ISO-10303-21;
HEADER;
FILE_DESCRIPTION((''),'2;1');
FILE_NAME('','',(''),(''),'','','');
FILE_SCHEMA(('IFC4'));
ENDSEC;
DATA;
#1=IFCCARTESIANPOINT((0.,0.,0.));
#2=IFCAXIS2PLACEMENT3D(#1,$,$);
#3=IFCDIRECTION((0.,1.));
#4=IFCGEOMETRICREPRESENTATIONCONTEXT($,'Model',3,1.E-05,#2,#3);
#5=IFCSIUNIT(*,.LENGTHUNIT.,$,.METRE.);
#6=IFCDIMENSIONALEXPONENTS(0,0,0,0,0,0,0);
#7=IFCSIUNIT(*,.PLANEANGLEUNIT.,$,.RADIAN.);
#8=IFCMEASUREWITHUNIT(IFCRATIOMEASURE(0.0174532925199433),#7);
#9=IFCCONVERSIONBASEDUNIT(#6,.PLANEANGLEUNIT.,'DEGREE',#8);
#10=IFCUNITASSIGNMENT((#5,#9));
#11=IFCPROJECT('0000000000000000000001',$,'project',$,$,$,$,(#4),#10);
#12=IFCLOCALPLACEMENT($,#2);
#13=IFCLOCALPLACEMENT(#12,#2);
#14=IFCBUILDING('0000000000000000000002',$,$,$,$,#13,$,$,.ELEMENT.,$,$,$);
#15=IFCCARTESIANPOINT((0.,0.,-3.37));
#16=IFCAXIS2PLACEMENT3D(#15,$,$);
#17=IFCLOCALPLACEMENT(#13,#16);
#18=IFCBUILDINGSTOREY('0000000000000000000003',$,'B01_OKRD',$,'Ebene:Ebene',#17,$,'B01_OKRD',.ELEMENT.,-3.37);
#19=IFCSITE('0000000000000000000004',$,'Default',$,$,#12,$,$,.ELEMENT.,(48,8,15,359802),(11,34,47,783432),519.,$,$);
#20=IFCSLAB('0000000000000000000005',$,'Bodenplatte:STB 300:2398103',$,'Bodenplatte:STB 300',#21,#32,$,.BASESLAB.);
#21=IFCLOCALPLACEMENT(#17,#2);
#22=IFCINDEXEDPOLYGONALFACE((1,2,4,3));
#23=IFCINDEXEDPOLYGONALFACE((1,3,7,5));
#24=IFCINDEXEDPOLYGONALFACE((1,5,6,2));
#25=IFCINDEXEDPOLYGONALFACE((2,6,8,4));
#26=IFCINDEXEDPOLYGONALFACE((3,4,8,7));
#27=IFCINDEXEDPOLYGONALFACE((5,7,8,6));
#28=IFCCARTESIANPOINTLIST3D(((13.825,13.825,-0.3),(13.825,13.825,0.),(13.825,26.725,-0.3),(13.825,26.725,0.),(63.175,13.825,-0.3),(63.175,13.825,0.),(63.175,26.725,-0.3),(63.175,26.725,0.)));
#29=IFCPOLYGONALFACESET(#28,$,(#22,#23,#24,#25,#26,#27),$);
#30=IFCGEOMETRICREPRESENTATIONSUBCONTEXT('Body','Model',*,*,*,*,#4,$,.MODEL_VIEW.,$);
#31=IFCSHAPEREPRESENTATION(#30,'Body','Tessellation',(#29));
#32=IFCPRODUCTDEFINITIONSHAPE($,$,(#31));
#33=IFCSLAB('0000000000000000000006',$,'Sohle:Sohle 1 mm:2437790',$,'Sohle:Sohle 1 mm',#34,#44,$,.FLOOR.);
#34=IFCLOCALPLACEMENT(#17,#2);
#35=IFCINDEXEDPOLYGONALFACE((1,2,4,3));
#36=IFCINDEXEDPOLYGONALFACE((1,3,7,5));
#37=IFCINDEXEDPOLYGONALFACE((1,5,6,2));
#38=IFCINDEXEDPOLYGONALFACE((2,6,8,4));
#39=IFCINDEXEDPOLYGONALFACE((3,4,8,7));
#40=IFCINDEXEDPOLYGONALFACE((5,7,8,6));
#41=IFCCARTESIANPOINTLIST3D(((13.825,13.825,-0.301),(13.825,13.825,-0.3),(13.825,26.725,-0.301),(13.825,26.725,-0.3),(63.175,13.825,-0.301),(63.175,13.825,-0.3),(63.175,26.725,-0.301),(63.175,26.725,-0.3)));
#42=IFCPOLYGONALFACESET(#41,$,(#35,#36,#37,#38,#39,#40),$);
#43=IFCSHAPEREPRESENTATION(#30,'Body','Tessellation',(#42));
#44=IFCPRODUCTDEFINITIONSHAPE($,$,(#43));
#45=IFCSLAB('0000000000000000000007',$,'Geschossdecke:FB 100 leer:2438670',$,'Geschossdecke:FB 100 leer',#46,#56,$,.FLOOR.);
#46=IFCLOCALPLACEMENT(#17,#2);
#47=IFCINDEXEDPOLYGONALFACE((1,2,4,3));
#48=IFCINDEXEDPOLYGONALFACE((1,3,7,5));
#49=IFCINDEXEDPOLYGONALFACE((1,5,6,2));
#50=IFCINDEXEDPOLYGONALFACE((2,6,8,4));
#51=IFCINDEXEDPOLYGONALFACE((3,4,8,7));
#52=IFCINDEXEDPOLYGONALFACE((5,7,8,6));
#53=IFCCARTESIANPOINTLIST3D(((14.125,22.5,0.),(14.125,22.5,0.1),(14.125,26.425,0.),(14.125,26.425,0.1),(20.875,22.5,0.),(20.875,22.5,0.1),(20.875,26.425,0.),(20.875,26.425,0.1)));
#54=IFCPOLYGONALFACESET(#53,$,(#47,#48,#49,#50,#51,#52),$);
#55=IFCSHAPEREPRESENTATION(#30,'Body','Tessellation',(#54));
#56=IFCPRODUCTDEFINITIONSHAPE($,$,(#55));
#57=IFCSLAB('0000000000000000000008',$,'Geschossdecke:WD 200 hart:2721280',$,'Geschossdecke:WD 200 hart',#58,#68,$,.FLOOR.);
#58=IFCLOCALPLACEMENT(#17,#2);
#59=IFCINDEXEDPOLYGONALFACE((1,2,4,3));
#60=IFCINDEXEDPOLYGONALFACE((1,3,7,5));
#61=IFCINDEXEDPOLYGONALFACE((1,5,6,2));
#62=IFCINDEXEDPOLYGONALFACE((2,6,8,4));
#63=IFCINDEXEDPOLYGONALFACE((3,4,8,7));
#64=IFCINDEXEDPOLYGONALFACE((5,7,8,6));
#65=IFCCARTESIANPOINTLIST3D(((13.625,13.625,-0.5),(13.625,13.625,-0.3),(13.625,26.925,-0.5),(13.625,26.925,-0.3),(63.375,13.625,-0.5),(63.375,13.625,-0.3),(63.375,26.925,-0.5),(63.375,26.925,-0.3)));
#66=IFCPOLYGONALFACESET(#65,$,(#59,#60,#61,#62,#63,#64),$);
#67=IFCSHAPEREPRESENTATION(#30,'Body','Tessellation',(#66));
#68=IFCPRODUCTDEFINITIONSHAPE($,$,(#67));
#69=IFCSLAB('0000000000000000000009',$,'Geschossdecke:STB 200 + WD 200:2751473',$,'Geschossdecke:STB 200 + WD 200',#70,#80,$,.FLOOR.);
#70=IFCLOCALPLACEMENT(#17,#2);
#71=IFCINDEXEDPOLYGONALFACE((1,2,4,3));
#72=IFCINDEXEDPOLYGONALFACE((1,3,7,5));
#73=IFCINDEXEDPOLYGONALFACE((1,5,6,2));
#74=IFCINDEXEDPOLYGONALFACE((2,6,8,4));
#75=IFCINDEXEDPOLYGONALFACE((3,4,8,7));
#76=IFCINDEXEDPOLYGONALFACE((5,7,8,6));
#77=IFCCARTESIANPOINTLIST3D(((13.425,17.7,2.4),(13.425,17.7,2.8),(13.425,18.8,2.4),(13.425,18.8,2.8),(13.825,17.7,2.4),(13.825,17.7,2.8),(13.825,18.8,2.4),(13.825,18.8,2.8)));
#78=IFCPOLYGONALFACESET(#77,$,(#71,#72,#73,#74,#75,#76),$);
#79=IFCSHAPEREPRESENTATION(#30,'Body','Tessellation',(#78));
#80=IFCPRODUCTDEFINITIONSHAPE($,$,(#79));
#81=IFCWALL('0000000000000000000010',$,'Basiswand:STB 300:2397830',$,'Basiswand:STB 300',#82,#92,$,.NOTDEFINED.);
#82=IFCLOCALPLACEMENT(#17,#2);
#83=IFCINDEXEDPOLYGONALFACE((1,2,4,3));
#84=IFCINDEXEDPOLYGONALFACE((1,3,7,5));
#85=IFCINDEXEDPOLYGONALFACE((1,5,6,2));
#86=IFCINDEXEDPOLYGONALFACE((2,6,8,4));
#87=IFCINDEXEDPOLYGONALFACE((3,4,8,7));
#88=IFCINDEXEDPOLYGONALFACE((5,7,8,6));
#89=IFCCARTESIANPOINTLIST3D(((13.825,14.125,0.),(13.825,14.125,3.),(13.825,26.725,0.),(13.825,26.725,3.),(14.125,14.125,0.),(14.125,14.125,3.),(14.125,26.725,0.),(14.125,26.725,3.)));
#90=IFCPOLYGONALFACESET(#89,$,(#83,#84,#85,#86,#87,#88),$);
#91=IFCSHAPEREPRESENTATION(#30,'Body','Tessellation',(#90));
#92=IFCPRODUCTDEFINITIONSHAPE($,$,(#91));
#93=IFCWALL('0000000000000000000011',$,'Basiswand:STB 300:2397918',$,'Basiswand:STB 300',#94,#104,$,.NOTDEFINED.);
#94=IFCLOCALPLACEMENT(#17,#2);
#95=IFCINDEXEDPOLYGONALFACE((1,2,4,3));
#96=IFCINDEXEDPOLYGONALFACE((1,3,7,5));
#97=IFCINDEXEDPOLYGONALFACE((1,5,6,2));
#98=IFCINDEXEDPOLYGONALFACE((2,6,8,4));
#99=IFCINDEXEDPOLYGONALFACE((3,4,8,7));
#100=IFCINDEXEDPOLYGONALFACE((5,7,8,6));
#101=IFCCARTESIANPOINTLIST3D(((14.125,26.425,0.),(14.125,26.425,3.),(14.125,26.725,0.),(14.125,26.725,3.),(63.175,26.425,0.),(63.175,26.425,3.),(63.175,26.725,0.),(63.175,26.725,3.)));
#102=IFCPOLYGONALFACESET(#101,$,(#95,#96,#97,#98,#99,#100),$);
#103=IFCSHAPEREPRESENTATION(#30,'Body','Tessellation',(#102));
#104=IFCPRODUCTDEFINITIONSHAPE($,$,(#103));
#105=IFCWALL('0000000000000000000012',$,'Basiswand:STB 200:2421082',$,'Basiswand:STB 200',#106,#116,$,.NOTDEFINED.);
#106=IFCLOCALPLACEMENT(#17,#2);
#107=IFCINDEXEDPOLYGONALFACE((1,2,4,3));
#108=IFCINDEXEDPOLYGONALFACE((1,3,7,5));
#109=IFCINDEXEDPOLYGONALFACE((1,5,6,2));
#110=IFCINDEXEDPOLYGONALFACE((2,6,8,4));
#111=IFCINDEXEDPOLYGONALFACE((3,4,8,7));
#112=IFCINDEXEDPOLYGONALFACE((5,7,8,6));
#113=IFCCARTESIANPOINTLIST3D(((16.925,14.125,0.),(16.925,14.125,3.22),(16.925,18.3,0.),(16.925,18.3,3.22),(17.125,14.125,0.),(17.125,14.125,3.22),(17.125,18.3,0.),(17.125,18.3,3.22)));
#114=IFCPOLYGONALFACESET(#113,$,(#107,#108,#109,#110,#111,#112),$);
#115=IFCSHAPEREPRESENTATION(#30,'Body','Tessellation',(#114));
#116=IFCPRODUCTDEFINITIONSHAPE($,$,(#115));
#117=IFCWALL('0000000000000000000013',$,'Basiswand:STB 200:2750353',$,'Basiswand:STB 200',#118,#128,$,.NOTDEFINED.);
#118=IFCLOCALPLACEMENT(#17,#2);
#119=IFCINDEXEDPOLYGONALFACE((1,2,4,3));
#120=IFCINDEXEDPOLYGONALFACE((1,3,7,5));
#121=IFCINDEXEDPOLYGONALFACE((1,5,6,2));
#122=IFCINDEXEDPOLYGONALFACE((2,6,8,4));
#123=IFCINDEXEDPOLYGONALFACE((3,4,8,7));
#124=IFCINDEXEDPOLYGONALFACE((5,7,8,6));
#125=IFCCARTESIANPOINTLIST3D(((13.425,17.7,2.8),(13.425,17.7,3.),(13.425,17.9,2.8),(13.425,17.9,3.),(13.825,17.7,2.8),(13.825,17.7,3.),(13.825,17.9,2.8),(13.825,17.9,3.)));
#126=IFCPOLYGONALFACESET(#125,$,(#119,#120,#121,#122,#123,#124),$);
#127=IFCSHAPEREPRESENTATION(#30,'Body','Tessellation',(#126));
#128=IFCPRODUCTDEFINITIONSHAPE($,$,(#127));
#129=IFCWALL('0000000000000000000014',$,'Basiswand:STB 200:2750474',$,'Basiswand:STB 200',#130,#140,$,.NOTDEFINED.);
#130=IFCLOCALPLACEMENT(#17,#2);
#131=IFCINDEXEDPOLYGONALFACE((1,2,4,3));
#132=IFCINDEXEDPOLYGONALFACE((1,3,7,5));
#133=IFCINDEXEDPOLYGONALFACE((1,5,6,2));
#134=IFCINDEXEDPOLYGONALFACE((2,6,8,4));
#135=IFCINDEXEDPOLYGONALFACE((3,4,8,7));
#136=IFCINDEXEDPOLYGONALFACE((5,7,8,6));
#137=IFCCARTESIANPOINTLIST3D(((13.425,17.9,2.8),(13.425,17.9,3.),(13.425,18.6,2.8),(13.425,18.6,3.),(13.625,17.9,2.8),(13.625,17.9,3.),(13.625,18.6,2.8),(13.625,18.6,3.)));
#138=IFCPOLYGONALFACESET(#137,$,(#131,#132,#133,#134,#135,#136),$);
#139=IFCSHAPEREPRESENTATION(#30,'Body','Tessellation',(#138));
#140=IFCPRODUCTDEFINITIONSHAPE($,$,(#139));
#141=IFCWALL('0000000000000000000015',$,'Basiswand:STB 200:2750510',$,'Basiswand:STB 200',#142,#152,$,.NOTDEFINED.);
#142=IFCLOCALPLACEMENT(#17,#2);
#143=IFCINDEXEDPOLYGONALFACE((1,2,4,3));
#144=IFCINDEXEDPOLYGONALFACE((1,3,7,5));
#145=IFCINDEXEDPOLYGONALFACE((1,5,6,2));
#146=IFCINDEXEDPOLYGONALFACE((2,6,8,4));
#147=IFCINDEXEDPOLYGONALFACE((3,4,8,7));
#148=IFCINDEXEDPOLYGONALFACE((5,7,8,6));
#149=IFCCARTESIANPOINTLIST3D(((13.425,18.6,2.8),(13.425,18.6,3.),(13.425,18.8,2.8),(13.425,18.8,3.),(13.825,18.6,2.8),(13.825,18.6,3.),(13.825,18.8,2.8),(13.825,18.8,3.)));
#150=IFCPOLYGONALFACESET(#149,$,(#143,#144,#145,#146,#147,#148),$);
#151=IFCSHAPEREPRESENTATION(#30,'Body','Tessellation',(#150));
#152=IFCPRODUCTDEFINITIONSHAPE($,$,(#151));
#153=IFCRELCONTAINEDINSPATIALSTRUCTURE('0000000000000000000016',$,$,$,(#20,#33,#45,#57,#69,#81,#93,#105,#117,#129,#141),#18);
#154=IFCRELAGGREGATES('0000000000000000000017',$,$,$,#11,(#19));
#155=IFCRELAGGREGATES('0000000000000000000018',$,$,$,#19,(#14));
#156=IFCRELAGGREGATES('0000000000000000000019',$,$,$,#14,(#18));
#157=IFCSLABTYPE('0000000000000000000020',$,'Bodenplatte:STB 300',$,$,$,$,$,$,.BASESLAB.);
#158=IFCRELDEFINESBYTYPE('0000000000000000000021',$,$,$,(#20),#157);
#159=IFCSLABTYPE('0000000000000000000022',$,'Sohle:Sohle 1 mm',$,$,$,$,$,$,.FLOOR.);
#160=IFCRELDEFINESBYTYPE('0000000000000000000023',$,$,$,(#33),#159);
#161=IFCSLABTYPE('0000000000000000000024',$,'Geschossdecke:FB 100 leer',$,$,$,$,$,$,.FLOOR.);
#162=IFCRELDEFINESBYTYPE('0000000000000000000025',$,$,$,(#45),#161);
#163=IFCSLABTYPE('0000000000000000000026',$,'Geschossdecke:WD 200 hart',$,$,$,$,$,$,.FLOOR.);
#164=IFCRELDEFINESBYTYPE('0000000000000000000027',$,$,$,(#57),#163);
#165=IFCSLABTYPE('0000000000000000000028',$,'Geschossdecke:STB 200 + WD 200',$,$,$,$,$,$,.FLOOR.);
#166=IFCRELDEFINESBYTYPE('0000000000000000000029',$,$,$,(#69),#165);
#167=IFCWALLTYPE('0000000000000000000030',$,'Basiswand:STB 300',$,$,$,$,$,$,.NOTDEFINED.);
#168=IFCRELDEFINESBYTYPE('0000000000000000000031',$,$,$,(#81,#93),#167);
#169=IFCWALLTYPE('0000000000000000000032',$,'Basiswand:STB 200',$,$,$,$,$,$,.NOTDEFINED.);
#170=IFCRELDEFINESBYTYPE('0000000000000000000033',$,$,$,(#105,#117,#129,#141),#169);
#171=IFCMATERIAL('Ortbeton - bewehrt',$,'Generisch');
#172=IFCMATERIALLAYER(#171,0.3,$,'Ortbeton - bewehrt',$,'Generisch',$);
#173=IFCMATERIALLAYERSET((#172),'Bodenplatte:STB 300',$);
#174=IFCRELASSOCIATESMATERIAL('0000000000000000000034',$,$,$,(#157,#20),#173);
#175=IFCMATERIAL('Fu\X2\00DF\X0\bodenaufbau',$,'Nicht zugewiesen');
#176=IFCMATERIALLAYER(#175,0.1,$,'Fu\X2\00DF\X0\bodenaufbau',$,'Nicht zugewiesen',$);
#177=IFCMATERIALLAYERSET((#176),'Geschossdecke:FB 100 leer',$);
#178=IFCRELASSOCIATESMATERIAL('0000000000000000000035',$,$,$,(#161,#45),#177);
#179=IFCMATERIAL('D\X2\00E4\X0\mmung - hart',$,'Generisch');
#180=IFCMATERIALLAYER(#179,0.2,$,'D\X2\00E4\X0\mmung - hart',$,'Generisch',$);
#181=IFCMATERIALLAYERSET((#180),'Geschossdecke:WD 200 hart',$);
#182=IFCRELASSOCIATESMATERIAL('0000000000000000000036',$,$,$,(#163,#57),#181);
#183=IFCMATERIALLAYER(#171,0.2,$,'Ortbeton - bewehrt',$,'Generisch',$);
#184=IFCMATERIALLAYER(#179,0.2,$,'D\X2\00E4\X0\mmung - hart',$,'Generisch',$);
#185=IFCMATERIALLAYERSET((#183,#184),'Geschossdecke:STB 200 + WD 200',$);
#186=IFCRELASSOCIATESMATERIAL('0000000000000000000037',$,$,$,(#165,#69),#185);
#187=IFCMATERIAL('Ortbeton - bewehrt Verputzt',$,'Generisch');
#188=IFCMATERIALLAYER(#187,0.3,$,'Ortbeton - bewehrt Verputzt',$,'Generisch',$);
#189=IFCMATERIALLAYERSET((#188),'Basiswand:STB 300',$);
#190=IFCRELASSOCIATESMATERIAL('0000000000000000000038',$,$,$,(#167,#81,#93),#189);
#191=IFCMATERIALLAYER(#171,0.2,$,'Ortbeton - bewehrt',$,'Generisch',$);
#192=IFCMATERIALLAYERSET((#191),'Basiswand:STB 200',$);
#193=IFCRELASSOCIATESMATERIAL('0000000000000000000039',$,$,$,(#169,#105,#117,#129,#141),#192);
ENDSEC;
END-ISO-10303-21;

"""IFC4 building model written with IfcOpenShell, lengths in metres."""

from ifc_helpers import new_model, entity, si_unit, converted_unit, direction, frame, frame_2d, origin, origin_2d_with_axis, place, context, subcontext, project, spatial, rectangle, extrude, material, layer, layer_set, layer_usage, type_object, element, save


model = new_model("IFC4")

# Units and contexts
model_context = context("Model", 3, precision=1e-05, world=origin(), true_north=direction((0.0, 1.0)))
body_context = subcontext(model_context, "Body", "Model", "MODEL_VIEW")
ifc_project = project(units=[si_unit("LENGTHUNIT", "METRE"), converted_unit("PLANEANGLEUNIT", "DEGREE", entity("IfcRatioMeasure", 0.0174532925199433), si_unit("PLANEANGLEUNIT", "RADIAN"), dimensions=[0, 0, 0, 0, 0, 0, 0])], contexts=[model_context])

# Site, building, storey
site_placement = place(None, frame((0.0, 0.0, 0.0)))
site = spatial("IfcSite", under=ifc_project, at=site_placement, Name="Default", CompositionType="ELEMENT", RefLatitude=(48, 8, 15, 359802), RefLongitude=(11, 34, 47, 783432), RefElevation=519.0)
building_placement = place(site_placement, origin())
building = spatial("IfcBuilding", under=site, at=building_placement, CompositionType="ELEMENT")
storey_placement = place(building_placement, frame((0.0, 0.0, -3.37)))
storey = spatial("IfcBuildingStorey", under=building, at=storey_placement, Name="B01_OKRD", ObjectType="Ebene:Ebene", LongName="B01_OKRD", CompositionType="ELEMENT", Elevation=-3.37)

# Slabs
ifc_material_1 = material(Name="Ortbeton - bewehrt", Category="Generisch")
ifc_layer_1 = layer(ifc_material_1, 0.3, Name="Ortbeton - bewehrt", Category="Generisch")
ifc_layer_set_1 = layer_set([ifc_layer_1], Name="Bodenplatte:STB 300")
ifc_layer_usage_1 = layer_usage(ifc_layer_set_1, "AXIS3", "POSITIVE", 0.0)
slab_type_1 = type_object("IfcSlabType", Name="Bodenplatte:STB 300", PredefinedType="BASESLAB", material=ifc_layer_set_1)
slab_1_placement = place(storey_placement, origin())
element("IfcSlab", 1, at=slab_1_placement, inside=storey, type_object=slab_type_1, material=ifc_layer_usage_1, Name="Bodenplatte:STB 300:2398103", ObjectType="Bodenplatte:STB 300", PredefinedType="BASESLAB", context=body_context, shape_type="SweptSolid", body=[
    extrude(rectangle(XDim=12.9, YDim=49.35, at=frame_2d((0.0, 0.0), x_axis=(1.0, 0.0))), frame((38.5, 20.275, 0.0), z_axis=(0.0, 0.0, -1.0), x_axis=(0.0, 1.0, 0.0)), (0.0, 0.0, 1.0), 0.3),
])
slab_type_2 = type_object("IfcSlabType", Name="Sohle:Sohle 1 mm", PredefinedType="FLOOR")
slab_2_placement = place(storey_placement, origin())
element("IfcSlab", 2, at=slab_2_placement, inside=storey, type_object=slab_type_2, Name="Sohle:Sohle 1 mm:2437790", ObjectType="Sohle:Sohle 1 mm", PredefinedType="FLOOR", context=body_context, shape_type="SweptSolid", body=[
    extrude(rectangle(XDim=12.9, YDim=49.35, at=frame_2d((0.0, 0.0), x_axis=(1.0, 0.0))), frame((38.5, 20.275, -0.301), z_axis=(0.0, 0.0, 1.0), x_axis=(0.0, 1.0, 0.0)), (0.0, 0.0, 1.0), 0.001),
])
ifc_material_2 = material(Name="Fußbodenaufbau", Category="Nicht zugewiesen")
ifc_layer_2 = layer(ifc_material_2, 0.1, Name="Fußbodenaufbau", Category="Nicht zugewiesen")
ifc_layer_set_2 = layer_set([ifc_layer_2], Name="Geschossdecke:FB 100 leer")
ifc_layer_usage_2 = layer_usage(ifc_layer_set_2, "AXIS3", "POSITIVE", 0.0)
slab_type_3 = type_object("IfcSlabType", Name="Geschossdecke:FB 100 leer", PredefinedType="FLOOR", material=ifc_layer_set_2)
slab_3_placement = place(storey_placement, origin())
element("IfcSlab", 3, at=slab_3_placement, inside=storey, type_object=slab_type_3, material=ifc_layer_usage_2, Name="Geschossdecke:FB 100 leer:2438670", ObjectType="Geschossdecke:FB 100 leer", PredefinedType="FLOOR", context=body_context, shape_type="SweptSolid", body=[
    extrude(rectangle(XDim=3.925, YDim=6.75, at=frame_2d((0.0, 0.0), x_axis=(1.0, 0.0))), frame((17.5, 24.4625, 0.1), z_axis=(0.0, 0.0, -1.0), x_axis=(0.0, 1.0, 0.0)), (0.0, 0.0, 1.0), 0.1),
])
ifc_material_3 = material(Name="Dämmung - hart", Category="Generisch")
ifc_layer_3 = layer(ifc_material_3, 0.2, Name="Dämmung - hart", Category="Generisch")
ifc_layer_set_3 = layer_set([ifc_layer_3], Name="Geschossdecke:WD 200 hart")
ifc_layer_usage_3 = layer_usage(ifc_layer_set_3, "AXIS3", "POSITIVE", 0.0)
slab_type_4 = type_object("IfcSlabType", Name="Geschossdecke:WD 200 hart", PredefinedType="FLOOR", material=ifc_layer_set_3)
slab_4_placement = place(storey_placement, origin())
element("IfcSlab", 4, at=slab_4_placement, inside=storey, type_object=slab_type_4, material=ifc_layer_usage_3, Name="Geschossdecke:WD 200 hart:2721280", ObjectType="Geschossdecke:WD 200 hart", PredefinedType="FLOOR", context=body_context, shape_type="SweptSolid", body=[
    extrude(rectangle(XDim=13.3, YDim=49.75, at=frame_2d((0.0, 0.0), x_axis=(1.0, 0.0))), frame((38.5, 20.275, -0.3), z_axis=(0.0, 0.0, -1.0), x_axis=(0.0, 1.0, 0.0)), (0.0, 0.0, 1.0), 0.2),
])
ifc_layer_4 = layer(ifc_material_1, 0.2, Name="Ortbeton - bewehrt", Category="Generisch")
ifc_layer_5 = layer(ifc_material_3, 0.2, Name="Dämmung - hart", Category="Generisch")
ifc_layer_set_4 = layer_set([ifc_layer_4, ifc_layer_5], Name="Geschossdecke:STB 200 + WD 200")
ifc_layer_usage_4 = layer_usage(ifc_layer_set_4, "AXIS3", "POSITIVE", 0.0)
slab_type_5 = type_object("IfcSlabType", Name="Geschossdecke:STB 200 + WD 200", PredefinedType="FLOOR", material=ifc_layer_set_4)
slab_5_placement = place(storey_placement, origin())
element("IfcSlab", 5, at=slab_5_placement, inside=storey, type_object=slab_type_5, material=ifc_layer_usage_4, Name="Geschossdecke:STB 200 + WD 200:2751473", ObjectType="Geschossdecke:STB 200 + WD 200", PredefinedType="FLOOR", context=body_context, shape_type="SweptSolid", body=[
    extrude(rectangle(XDim=1.1, YDim=0.4, at=origin_2d_with_axis()), frame((13.625, 18.25, 2.8), z_axis=(0.0, 0.0, -1.0), x_axis=(0.0, 1.0, 0.0)), (0.0, 0.0, 1.0), 0.4),
])

# Walls
ifc_material_4 = material(Name="Ortbeton - bewehrt Verputzt", Category="Generisch")
ifc_layer_6 = layer(ifc_material_4, 0.3, Name="Ortbeton - bewehrt Verputzt", Category="Generisch")
ifc_layer_set_5 = layer_set([ifc_layer_6], Name="Basiswand:STB 300")
ifc_layer_usage_5 = layer_usage(ifc_layer_set_5, "AXIS2", "NEGATIVE", 0.15)
wall_type_1 = type_object("IfcWallType", Name="Basiswand:STB 300", PredefinedType="NOTDEFINED", material=ifc_layer_set_5)
wall_1_placement = place(storey_placement, frame((13.975, 14.125, 0.0), z_axis=(0.0, 0.0, 1.0), x_axis=(0.0, 1.0, 0.0)))
element("IfcWall", 6, at=wall_1_placement, inside=storey, type_object=wall_type_1, material=ifc_layer_usage_5, Name="Basiswand:STB 300:2397830", ObjectType="Basiswand:STB 300", PredefinedType="NOTDEFINED", context=body_context, shape_type="SweptSolid", body=[
    extrude(rectangle(XDim=12.6, YDim=0.3, at=frame_2d((6.3, 0.0), x_axis=(-1.0, 0.0))), origin(), (0.0, 0.0, 1.0), 3.0),
])
ifc_layer_usage_6 = layer_usage(ifc_layer_set_5, "AXIS2", "NEGATIVE", 0.15)
wall_2_placement = place(storey_placement, frame((14.125, 26.575, 0.0)))
element("IfcWall", 7, at=wall_2_placement, inside=storey, type_object=wall_type_1, material=ifc_layer_usage_6, Name="Basiswand:STB 300:2397918", ObjectType="Basiswand:STB 300", PredefinedType="NOTDEFINED", context=body_context, shape_type="SweptSolid", body=[
    extrude(rectangle(XDim=49.05, YDim=0.3, at=frame_2d((24.525, 0.0), x_axis=(-1.0, 0.0))), origin(), (0.0, 0.0, 1.0), 3.0),
])
ifc_layer_7 = layer(ifc_material_1, 0.2, Name="Ortbeton - bewehrt", Category="Generisch")
ifc_layer_set_6 = layer_set([ifc_layer_7], Name="Basiswand:STB 200")
ifc_layer_usage_7 = layer_usage(ifc_layer_set_6, "AXIS2", "POSITIVE", -0.1)
wall_type_2 = type_object("IfcWallType", Name="Basiswand:STB 200", PredefinedType="NOTDEFINED", material=ifc_layer_set_6)
wall_3_placement = place(storey_placement, frame((17.025, 14.125, 0.0), z_axis=(0.0, 0.0, 1.0), x_axis=(0.0, 1.0, 0.0)))
element("IfcWall", 8, at=wall_3_placement, inside=storey, type_object=wall_type_2, material=ifc_layer_usage_7, Name="Basiswand:STB 200:2421082", ObjectType="Basiswand:STB 200", PredefinedType="NOTDEFINED", context=body_context, shape_type="SweptSolid", body=[
    extrude(rectangle(XDim=4.175, YDim=0.2, at=frame_2d((2.0875, 0.0), x_axis=(-1.0, 0.0))), origin(), (0.0, 0.0, 1.0), 3.22),
])

# Walls
ifc_layer_usage_8 = layer_usage(ifc_layer_set_6, "AXIS2", "NEGATIVE", 0.1)
wall_4_placement = place(storey_placement, frame((13.825, 17.8, 2.8), z_axis=(0.0, 0.0, 1.0), x_axis=(-1.0, 0.0, 0.0)))
element("IfcWall", 9, at=wall_4_placement, inside=storey, type_object=wall_type_2, material=ifc_layer_usage_8, Name="Basiswand:STB 200:2750353", ObjectType="Basiswand:STB 200", PredefinedType="NOTDEFINED", context=body_context, shape_type="SweptSolid", body=[
    extrude(rectangle(XDim=0.4, YDim=0.2, at=frame_2d((0.2, 0.0), x_axis=(-1.0, 0.0))), origin(), (0.0, 0.0, 1.0), 0.2),
])
ifc_layer_usage_9 = layer_usage(ifc_layer_set_6, "AXIS2", "NEGATIVE", 0.1)
wall_5_placement = place(storey_placement, frame((13.525, 17.9, 2.8), z_axis=(0.0, 0.0, 1.0), x_axis=(0.0, 1.0, 0.0)))
element("IfcWall", 10, at=wall_5_placement, inside=storey, type_object=wall_type_2, material=ifc_layer_usage_9, Name="Basiswand:STB 200:2750474", ObjectType="Basiswand:STB 200", PredefinedType="NOTDEFINED", context=body_context, shape_type="SweptSolid", body=[
    extrude(rectangle(XDim=0.7, YDim=0.2, at=frame_2d((0.35, 0.0), x_axis=(-1.0, 0.0))), origin(), (0.0, 0.0, 1.0), 0.2),
])
ifc_layer_usage_10 = layer_usage(ifc_layer_set_6, "AXIS2", "NEGATIVE", 0.1)
wall_6_placement = place(storey_placement, frame((13.425, 18.7, 2.8)))
element("IfcWall", 11, at=wall_6_placement, inside=storey, type_object=wall_type_2, material=ifc_layer_usage_10, Name="Basiswand:STB 200:2750510", ObjectType="Basiswand:STB 200", PredefinedType="NOTDEFINED", context=body_context, shape_type="SweptSolid", body=[
    extrude(rectangle(XDim=0.4, YDim=0.2, at=frame_2d((0.2, 0.0), x_axis=(-1.0, 0.0))), origin(), (0.0, 0.0, 1.0), 0.2),
])

save(model, "model.ifc")
